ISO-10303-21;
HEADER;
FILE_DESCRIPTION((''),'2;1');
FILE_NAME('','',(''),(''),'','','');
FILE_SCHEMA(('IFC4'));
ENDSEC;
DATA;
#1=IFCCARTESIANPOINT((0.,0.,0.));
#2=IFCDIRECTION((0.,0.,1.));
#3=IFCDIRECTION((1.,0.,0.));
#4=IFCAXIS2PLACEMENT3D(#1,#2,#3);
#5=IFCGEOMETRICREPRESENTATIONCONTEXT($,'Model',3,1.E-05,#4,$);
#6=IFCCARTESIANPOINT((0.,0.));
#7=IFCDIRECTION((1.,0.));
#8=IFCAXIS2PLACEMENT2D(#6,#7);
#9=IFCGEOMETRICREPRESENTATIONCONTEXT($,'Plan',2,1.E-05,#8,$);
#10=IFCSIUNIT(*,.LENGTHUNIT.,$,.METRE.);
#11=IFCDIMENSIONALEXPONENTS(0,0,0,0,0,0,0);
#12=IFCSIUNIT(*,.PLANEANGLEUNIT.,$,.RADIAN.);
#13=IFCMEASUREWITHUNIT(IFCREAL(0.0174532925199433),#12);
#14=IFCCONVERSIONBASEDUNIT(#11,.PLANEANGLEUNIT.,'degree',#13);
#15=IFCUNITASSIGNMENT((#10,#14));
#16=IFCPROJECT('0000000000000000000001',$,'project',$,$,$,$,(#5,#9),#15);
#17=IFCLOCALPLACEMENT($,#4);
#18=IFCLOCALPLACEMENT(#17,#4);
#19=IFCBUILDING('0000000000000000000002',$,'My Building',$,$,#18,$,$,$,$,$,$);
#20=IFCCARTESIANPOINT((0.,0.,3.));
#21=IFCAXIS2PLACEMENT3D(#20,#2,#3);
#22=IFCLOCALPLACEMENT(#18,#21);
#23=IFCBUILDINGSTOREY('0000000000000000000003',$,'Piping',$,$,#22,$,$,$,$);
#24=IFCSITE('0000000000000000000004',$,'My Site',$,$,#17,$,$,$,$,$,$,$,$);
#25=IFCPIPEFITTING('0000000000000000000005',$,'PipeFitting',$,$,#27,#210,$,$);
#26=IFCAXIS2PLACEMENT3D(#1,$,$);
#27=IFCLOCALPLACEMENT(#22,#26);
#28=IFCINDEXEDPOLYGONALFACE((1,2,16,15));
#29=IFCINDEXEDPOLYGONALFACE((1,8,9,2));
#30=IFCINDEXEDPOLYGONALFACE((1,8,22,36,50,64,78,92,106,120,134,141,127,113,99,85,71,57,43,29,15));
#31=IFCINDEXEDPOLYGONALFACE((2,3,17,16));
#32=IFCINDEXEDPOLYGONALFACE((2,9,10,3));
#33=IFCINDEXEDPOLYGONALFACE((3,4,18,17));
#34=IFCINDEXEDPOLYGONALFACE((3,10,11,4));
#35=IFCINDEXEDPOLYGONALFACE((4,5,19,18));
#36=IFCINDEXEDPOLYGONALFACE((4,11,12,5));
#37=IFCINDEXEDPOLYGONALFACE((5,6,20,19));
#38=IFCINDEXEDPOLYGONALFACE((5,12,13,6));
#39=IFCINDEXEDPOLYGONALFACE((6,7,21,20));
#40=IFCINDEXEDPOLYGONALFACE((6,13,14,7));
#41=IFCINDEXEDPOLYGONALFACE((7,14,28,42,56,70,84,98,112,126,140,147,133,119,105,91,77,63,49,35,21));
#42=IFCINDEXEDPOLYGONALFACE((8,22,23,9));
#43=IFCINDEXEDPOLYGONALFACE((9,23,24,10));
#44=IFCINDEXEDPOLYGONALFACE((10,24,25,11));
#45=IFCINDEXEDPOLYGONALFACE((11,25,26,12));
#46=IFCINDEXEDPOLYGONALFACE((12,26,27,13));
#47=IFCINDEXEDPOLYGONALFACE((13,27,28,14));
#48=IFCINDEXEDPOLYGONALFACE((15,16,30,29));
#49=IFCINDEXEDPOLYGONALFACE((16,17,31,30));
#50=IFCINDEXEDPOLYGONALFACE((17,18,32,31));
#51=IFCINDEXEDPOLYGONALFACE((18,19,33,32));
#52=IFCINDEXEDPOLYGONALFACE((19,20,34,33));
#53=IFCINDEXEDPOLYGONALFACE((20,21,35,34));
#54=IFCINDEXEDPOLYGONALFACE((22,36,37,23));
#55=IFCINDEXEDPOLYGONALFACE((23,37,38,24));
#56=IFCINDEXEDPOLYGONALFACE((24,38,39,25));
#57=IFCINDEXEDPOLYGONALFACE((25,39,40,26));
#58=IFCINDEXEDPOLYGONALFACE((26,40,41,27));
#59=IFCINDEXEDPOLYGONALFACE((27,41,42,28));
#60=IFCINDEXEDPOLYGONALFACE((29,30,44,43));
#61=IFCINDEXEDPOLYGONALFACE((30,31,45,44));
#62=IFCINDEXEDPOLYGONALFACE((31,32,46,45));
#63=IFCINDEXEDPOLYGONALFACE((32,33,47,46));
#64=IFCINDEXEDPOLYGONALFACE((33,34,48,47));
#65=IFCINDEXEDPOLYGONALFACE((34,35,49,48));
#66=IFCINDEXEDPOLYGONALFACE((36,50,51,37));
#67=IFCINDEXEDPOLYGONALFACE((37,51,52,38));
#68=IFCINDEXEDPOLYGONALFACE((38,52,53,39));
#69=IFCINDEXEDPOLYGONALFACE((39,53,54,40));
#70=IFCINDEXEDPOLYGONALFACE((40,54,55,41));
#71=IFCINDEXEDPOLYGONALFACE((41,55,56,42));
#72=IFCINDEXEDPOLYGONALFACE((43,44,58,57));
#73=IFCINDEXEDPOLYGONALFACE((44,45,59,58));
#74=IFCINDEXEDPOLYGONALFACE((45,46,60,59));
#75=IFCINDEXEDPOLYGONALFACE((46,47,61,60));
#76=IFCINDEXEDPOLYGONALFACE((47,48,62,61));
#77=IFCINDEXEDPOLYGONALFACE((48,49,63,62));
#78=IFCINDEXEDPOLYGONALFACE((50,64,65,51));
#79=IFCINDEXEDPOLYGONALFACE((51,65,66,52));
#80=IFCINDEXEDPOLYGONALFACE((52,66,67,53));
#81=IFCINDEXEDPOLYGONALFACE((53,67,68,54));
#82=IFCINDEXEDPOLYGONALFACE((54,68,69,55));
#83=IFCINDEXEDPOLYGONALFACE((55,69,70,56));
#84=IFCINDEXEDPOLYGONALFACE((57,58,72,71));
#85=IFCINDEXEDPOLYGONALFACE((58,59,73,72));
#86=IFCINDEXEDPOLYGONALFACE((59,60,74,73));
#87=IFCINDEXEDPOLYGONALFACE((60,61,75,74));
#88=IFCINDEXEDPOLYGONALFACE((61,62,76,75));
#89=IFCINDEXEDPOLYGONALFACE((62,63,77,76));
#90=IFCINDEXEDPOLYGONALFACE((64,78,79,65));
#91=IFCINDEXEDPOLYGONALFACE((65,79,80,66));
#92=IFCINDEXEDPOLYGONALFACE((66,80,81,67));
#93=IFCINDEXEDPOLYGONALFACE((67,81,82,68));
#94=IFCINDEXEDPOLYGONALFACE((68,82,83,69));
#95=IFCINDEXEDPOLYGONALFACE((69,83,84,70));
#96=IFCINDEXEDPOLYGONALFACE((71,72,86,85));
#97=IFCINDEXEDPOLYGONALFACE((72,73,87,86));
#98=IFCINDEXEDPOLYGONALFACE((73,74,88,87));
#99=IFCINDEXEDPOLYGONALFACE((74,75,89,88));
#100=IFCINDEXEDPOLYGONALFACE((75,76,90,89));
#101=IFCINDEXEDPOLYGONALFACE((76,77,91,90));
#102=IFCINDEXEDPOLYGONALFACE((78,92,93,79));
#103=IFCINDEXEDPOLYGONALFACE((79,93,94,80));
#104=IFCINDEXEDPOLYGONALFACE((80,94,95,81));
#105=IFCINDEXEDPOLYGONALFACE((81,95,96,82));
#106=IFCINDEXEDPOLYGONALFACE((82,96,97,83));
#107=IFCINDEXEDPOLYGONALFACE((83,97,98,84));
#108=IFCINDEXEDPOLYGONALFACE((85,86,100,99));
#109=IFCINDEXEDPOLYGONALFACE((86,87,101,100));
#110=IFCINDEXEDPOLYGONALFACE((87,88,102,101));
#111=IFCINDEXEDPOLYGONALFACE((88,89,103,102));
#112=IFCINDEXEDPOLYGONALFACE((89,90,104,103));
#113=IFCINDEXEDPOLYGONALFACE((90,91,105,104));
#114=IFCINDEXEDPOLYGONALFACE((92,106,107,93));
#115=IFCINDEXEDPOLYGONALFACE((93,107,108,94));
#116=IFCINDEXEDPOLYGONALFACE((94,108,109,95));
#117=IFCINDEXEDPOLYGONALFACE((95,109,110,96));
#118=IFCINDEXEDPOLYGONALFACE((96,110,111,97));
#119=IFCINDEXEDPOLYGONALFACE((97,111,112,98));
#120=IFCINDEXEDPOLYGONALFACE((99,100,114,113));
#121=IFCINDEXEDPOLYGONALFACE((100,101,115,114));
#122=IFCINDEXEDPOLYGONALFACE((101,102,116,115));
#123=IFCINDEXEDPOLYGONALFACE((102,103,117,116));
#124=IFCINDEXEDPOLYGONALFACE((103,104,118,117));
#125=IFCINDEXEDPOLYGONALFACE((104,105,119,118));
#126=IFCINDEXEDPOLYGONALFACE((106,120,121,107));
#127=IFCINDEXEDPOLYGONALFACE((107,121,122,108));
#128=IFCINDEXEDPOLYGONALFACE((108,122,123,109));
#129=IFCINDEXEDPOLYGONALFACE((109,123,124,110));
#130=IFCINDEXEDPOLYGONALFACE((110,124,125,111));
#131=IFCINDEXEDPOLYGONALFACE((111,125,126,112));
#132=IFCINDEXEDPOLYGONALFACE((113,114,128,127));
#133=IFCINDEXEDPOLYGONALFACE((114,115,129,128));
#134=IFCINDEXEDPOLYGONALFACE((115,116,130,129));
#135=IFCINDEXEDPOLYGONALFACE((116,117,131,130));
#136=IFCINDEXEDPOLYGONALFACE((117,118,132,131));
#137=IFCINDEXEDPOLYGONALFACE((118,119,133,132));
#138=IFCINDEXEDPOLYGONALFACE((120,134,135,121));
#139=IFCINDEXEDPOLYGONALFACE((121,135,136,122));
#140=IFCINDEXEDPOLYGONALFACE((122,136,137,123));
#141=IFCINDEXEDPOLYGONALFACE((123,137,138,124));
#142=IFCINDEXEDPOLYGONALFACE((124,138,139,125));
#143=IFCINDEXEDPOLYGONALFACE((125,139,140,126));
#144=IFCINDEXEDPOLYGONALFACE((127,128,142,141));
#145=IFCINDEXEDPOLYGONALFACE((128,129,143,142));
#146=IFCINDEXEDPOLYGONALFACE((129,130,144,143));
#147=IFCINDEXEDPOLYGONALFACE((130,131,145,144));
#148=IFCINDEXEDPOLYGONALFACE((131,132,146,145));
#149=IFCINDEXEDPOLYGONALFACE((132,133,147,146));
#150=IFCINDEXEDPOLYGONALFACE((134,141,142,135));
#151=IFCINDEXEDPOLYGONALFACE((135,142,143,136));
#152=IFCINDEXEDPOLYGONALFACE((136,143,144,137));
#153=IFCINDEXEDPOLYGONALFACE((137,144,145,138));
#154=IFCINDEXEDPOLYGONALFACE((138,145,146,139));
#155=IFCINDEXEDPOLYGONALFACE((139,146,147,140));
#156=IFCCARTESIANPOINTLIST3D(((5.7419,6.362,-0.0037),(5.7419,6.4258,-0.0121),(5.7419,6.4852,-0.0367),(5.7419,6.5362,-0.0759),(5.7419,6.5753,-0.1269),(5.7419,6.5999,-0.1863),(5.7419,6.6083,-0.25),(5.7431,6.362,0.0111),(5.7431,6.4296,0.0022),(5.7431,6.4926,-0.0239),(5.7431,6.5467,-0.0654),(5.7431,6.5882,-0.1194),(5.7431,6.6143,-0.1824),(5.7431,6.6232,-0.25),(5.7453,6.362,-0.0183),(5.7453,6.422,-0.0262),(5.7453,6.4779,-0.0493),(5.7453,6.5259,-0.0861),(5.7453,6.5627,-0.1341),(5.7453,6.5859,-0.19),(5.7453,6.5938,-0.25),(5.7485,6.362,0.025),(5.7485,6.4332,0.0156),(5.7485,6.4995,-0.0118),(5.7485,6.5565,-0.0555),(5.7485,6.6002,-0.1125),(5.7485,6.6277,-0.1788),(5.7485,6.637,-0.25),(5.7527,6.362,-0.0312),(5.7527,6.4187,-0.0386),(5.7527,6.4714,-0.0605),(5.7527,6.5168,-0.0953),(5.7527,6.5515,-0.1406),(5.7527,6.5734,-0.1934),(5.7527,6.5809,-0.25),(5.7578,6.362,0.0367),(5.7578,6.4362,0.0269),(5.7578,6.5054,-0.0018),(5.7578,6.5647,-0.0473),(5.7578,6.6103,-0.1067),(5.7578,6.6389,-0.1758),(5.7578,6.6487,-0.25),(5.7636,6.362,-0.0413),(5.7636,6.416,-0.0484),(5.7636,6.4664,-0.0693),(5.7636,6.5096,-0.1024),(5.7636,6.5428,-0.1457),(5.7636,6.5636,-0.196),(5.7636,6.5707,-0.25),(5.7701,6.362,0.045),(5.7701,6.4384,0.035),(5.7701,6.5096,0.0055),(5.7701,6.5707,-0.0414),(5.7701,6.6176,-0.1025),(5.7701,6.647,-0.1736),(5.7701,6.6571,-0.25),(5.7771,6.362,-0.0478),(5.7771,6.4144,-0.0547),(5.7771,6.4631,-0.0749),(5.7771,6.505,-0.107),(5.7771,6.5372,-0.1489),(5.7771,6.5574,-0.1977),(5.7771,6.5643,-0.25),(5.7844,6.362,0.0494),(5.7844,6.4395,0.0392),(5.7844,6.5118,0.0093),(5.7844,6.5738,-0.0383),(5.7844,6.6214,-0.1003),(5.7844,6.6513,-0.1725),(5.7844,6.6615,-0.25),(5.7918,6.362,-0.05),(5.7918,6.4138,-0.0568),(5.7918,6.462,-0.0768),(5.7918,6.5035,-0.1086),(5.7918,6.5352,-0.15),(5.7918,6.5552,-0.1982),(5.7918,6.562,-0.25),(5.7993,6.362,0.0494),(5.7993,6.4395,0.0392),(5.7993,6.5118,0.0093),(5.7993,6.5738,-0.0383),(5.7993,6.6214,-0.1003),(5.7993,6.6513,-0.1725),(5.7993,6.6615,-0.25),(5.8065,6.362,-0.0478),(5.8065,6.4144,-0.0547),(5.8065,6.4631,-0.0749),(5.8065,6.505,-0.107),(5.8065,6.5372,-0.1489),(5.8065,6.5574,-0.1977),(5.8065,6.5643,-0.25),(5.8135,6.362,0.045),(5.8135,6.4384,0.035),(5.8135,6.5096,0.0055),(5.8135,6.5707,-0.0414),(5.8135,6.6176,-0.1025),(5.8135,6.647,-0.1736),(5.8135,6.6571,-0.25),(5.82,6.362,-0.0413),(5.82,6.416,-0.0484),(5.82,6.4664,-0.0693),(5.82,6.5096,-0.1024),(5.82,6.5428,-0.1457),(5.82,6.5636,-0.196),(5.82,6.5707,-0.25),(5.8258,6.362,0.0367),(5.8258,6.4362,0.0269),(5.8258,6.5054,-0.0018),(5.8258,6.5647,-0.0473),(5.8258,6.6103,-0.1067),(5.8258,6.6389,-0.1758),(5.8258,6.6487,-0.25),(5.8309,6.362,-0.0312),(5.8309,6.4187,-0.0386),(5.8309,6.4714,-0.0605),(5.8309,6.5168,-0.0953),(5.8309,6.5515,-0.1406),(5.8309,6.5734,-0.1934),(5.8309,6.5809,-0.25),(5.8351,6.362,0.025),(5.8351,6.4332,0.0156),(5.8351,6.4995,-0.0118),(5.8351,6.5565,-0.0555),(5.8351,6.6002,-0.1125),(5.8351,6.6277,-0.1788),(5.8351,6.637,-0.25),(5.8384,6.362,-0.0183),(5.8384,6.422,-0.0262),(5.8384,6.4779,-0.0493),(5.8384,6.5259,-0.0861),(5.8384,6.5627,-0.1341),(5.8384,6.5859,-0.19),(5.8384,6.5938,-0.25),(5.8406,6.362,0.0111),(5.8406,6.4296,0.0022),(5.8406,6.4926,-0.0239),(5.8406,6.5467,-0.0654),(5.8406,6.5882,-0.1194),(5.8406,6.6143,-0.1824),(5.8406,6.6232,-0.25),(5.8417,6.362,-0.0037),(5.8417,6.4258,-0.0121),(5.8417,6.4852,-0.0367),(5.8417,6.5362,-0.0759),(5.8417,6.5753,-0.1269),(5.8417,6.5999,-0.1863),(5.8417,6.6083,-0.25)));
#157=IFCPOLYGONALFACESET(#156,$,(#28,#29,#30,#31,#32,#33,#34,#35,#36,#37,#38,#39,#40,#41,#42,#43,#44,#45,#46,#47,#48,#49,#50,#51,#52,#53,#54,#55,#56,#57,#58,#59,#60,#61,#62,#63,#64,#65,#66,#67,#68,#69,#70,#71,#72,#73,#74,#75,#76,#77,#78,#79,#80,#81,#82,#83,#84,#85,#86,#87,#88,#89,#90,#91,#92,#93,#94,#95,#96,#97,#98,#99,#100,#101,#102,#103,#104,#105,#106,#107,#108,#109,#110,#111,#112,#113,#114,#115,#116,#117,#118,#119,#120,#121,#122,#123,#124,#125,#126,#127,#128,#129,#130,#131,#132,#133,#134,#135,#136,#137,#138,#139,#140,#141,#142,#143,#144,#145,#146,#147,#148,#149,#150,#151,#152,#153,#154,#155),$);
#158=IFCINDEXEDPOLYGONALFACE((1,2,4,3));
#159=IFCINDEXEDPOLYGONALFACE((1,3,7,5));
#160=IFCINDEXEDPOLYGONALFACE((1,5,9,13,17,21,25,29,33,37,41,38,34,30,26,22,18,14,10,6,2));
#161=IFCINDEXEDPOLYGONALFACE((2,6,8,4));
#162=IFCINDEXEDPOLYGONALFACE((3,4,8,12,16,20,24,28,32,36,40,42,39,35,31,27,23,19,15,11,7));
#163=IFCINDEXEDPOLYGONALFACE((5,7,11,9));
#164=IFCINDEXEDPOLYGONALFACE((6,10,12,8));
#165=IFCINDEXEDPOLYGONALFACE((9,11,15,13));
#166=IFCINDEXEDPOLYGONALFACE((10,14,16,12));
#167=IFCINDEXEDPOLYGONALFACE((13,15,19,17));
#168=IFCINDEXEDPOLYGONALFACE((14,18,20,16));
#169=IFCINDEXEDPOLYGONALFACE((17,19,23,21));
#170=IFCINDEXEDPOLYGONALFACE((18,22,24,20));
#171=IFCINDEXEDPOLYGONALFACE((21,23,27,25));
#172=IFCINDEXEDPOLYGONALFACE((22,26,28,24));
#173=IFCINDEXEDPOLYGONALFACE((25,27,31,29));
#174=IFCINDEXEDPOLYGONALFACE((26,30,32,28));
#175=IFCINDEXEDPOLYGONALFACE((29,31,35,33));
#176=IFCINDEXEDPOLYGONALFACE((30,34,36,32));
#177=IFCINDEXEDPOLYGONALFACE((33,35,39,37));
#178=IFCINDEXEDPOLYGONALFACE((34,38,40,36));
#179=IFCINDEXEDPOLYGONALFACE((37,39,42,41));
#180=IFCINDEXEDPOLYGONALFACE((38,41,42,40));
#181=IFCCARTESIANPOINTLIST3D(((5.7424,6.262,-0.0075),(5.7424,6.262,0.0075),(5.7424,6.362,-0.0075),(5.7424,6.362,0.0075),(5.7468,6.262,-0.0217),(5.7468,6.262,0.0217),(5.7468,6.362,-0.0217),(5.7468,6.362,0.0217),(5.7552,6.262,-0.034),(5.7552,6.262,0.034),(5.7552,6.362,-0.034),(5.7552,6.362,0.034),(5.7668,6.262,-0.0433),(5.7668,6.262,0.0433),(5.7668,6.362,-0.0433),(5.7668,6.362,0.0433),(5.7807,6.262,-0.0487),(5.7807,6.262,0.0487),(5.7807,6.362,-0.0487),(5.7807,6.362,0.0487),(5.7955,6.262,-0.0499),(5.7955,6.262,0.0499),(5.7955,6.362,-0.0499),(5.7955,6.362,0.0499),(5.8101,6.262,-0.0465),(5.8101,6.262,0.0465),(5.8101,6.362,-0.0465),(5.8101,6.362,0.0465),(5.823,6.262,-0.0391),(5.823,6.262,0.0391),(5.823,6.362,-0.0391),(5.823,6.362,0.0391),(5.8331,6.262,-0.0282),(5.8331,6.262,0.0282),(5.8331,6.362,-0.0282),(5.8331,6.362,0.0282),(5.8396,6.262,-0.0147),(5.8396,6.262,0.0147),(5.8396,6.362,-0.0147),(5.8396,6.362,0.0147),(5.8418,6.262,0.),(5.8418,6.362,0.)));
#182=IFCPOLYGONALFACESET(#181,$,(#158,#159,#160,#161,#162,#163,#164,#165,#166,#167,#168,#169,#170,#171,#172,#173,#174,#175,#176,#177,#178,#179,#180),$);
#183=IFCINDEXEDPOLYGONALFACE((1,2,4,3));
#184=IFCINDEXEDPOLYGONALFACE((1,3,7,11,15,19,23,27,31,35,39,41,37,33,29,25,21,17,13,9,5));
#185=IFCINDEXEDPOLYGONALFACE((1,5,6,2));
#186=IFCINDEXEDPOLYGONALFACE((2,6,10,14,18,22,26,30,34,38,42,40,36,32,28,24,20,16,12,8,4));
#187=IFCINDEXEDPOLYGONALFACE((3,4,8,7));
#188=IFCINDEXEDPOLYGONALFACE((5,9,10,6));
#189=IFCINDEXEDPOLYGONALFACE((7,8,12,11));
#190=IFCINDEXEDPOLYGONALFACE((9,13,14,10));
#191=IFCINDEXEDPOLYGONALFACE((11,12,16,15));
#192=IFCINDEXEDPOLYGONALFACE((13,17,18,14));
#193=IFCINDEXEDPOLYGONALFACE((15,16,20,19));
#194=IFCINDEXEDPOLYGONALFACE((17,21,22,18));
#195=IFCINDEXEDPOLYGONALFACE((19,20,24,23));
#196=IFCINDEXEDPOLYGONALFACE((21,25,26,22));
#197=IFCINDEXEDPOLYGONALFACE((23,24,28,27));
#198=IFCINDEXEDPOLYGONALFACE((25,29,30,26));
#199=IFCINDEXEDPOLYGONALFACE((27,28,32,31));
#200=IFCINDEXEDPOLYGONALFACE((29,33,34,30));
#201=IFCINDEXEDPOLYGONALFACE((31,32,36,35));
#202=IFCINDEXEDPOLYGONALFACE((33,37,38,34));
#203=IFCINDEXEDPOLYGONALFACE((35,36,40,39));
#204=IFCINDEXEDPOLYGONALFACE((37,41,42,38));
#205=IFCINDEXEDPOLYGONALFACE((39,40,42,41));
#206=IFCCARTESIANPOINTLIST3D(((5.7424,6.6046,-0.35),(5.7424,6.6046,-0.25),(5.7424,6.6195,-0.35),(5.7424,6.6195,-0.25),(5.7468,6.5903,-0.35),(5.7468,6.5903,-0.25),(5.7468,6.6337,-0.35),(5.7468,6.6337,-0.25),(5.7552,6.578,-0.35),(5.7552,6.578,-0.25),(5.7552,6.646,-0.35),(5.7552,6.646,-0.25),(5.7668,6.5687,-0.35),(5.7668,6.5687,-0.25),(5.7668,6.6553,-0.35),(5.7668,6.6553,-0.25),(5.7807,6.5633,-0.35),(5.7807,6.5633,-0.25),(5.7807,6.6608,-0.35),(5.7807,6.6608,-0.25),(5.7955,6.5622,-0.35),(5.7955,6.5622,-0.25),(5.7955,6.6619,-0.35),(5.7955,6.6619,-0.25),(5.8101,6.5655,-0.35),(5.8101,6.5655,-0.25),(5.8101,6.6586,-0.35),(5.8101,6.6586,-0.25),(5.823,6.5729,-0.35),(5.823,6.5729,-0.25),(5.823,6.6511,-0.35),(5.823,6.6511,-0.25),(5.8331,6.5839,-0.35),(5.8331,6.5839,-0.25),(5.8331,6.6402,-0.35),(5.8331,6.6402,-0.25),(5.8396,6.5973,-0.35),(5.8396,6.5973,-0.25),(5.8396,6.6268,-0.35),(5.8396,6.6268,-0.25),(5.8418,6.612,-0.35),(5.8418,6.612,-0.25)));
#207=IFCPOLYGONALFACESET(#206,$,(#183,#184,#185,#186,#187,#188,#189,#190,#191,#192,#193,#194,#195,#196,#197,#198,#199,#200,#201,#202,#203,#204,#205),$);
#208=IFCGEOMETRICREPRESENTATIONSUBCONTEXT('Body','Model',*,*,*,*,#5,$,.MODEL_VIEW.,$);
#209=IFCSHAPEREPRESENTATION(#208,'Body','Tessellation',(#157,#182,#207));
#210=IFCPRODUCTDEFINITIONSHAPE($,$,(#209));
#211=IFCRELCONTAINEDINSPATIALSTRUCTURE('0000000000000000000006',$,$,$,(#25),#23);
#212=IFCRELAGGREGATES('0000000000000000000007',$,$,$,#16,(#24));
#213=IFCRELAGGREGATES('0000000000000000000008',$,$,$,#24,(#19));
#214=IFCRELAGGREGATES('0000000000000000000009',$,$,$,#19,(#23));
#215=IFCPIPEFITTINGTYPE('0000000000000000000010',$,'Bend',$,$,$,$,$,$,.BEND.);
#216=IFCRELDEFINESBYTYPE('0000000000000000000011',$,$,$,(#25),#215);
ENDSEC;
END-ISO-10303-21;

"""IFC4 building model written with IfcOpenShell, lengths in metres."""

from ifc_helpers import new_model, entity, si_unit, converted_unit, frame, origin_with_axes, origin_2d_with_axis, place, context, subcontext, project, spatial, circle, extrude, source, transform, mapped, type_object, type_shapes, element, save


model = new_model("IFC4")

# Units and contexts
model_context = context("Model", 3, precision=1e-05, world=origin_with_axes())
plan_context = context("Plan", 2, precision=1e-05, world=origin_2d_with_axis())
body_context = subcontext(model_context, "Body", "Model", "MODEL_VIEW")
ifc_project = project(units=[si_unit("LENGTHUNIT", "METRE"), converted_unit("PLANEANGLEUNIT", "degree", entity("IfcReal", 0.0174532925199433), si_unit("PLANEANGLEUNIT", "RADIAN"), dimensions=[0, 0, 0, 0, 0, 0, 0])], contexts=[model_context, plan_context])

# Site, building, storey
site_placement = place(None, origin_with_axes())
site = spatial("IfcSite", under=ifc_project, at=site_placement, Name="My Site")
building_placement = place(site_placement, origin_with_axes())
building = spatial("IfcBuilding", under=site, at=building_placement, Name="My Building")
storey_placement = place(building_placement, frame((0.0, 0.0, 3.0), z_axis=(0.0, 0.0, 1.0), x_axis=(1.0, 0.0, 0.0)))
storey = spatial("IfcBuildingStorey", under=building, at=storey_placement, Name="Piping")

# Pipe fitting
pipe_fitting_type = type_object("IfcPipeFittingType", Name="Bend", PredefinedType="BEND")
shared_shape = source(origin_with_axes(), body_context, "Body", "SolidModel", [
    entity("IfcSweptDiskSolid", entity("IfcIndexedPolyCurve", entity("IfcCartesianPointList3D", [[0.0, 0.0, -0.1], [0.0, -0.0732, -0.2768], [0.0, -0.25, -0.35]]), [entity("IfcArcIndex", [1, 2, 3])]), 0.05),
    extrude(circle(Radius=0.05), origin_with_axes(), (0.0, 0.0, -1.0), 0.1),
    extrude(circle(Radius=0.05), frame((0.0, -0.25, -0.35), z_axis=(0.0, -1.0, 0.0), x_axis=(1.0, 0.0, 0.0)), (0.0, 0.0, 1.0), 0.1),
])
type_shapes(pipe_fitting_type, [shared_shape])
for number, where, z_axis, x_axis, name in (
    (1, (5.7918, 6.262, 0.0), (0.0, -1.0, 0.0), (1.0, 0.0, 0.0), "PipeFitting"),
):
    element("IfcPipeFitting", number, at=place(storey_placement, frame(where, z_axis=z_axis, x_axis=x_axis)), inside=storey, type_object=pipe_fitting_type, Name=name, context=body_context, shape_type="MappedRepresentation", body=[
        mapped(shared_shape, transform((0.0, 0.0, 0.0), x_axis=(1.0, 0.0, 0.0), y_axis=(0.0, 1.0, 0.0), z_axis=(0.0, 0.0, 1.0), scale=1.0)),
    ])

save(model, "model.ifc")
